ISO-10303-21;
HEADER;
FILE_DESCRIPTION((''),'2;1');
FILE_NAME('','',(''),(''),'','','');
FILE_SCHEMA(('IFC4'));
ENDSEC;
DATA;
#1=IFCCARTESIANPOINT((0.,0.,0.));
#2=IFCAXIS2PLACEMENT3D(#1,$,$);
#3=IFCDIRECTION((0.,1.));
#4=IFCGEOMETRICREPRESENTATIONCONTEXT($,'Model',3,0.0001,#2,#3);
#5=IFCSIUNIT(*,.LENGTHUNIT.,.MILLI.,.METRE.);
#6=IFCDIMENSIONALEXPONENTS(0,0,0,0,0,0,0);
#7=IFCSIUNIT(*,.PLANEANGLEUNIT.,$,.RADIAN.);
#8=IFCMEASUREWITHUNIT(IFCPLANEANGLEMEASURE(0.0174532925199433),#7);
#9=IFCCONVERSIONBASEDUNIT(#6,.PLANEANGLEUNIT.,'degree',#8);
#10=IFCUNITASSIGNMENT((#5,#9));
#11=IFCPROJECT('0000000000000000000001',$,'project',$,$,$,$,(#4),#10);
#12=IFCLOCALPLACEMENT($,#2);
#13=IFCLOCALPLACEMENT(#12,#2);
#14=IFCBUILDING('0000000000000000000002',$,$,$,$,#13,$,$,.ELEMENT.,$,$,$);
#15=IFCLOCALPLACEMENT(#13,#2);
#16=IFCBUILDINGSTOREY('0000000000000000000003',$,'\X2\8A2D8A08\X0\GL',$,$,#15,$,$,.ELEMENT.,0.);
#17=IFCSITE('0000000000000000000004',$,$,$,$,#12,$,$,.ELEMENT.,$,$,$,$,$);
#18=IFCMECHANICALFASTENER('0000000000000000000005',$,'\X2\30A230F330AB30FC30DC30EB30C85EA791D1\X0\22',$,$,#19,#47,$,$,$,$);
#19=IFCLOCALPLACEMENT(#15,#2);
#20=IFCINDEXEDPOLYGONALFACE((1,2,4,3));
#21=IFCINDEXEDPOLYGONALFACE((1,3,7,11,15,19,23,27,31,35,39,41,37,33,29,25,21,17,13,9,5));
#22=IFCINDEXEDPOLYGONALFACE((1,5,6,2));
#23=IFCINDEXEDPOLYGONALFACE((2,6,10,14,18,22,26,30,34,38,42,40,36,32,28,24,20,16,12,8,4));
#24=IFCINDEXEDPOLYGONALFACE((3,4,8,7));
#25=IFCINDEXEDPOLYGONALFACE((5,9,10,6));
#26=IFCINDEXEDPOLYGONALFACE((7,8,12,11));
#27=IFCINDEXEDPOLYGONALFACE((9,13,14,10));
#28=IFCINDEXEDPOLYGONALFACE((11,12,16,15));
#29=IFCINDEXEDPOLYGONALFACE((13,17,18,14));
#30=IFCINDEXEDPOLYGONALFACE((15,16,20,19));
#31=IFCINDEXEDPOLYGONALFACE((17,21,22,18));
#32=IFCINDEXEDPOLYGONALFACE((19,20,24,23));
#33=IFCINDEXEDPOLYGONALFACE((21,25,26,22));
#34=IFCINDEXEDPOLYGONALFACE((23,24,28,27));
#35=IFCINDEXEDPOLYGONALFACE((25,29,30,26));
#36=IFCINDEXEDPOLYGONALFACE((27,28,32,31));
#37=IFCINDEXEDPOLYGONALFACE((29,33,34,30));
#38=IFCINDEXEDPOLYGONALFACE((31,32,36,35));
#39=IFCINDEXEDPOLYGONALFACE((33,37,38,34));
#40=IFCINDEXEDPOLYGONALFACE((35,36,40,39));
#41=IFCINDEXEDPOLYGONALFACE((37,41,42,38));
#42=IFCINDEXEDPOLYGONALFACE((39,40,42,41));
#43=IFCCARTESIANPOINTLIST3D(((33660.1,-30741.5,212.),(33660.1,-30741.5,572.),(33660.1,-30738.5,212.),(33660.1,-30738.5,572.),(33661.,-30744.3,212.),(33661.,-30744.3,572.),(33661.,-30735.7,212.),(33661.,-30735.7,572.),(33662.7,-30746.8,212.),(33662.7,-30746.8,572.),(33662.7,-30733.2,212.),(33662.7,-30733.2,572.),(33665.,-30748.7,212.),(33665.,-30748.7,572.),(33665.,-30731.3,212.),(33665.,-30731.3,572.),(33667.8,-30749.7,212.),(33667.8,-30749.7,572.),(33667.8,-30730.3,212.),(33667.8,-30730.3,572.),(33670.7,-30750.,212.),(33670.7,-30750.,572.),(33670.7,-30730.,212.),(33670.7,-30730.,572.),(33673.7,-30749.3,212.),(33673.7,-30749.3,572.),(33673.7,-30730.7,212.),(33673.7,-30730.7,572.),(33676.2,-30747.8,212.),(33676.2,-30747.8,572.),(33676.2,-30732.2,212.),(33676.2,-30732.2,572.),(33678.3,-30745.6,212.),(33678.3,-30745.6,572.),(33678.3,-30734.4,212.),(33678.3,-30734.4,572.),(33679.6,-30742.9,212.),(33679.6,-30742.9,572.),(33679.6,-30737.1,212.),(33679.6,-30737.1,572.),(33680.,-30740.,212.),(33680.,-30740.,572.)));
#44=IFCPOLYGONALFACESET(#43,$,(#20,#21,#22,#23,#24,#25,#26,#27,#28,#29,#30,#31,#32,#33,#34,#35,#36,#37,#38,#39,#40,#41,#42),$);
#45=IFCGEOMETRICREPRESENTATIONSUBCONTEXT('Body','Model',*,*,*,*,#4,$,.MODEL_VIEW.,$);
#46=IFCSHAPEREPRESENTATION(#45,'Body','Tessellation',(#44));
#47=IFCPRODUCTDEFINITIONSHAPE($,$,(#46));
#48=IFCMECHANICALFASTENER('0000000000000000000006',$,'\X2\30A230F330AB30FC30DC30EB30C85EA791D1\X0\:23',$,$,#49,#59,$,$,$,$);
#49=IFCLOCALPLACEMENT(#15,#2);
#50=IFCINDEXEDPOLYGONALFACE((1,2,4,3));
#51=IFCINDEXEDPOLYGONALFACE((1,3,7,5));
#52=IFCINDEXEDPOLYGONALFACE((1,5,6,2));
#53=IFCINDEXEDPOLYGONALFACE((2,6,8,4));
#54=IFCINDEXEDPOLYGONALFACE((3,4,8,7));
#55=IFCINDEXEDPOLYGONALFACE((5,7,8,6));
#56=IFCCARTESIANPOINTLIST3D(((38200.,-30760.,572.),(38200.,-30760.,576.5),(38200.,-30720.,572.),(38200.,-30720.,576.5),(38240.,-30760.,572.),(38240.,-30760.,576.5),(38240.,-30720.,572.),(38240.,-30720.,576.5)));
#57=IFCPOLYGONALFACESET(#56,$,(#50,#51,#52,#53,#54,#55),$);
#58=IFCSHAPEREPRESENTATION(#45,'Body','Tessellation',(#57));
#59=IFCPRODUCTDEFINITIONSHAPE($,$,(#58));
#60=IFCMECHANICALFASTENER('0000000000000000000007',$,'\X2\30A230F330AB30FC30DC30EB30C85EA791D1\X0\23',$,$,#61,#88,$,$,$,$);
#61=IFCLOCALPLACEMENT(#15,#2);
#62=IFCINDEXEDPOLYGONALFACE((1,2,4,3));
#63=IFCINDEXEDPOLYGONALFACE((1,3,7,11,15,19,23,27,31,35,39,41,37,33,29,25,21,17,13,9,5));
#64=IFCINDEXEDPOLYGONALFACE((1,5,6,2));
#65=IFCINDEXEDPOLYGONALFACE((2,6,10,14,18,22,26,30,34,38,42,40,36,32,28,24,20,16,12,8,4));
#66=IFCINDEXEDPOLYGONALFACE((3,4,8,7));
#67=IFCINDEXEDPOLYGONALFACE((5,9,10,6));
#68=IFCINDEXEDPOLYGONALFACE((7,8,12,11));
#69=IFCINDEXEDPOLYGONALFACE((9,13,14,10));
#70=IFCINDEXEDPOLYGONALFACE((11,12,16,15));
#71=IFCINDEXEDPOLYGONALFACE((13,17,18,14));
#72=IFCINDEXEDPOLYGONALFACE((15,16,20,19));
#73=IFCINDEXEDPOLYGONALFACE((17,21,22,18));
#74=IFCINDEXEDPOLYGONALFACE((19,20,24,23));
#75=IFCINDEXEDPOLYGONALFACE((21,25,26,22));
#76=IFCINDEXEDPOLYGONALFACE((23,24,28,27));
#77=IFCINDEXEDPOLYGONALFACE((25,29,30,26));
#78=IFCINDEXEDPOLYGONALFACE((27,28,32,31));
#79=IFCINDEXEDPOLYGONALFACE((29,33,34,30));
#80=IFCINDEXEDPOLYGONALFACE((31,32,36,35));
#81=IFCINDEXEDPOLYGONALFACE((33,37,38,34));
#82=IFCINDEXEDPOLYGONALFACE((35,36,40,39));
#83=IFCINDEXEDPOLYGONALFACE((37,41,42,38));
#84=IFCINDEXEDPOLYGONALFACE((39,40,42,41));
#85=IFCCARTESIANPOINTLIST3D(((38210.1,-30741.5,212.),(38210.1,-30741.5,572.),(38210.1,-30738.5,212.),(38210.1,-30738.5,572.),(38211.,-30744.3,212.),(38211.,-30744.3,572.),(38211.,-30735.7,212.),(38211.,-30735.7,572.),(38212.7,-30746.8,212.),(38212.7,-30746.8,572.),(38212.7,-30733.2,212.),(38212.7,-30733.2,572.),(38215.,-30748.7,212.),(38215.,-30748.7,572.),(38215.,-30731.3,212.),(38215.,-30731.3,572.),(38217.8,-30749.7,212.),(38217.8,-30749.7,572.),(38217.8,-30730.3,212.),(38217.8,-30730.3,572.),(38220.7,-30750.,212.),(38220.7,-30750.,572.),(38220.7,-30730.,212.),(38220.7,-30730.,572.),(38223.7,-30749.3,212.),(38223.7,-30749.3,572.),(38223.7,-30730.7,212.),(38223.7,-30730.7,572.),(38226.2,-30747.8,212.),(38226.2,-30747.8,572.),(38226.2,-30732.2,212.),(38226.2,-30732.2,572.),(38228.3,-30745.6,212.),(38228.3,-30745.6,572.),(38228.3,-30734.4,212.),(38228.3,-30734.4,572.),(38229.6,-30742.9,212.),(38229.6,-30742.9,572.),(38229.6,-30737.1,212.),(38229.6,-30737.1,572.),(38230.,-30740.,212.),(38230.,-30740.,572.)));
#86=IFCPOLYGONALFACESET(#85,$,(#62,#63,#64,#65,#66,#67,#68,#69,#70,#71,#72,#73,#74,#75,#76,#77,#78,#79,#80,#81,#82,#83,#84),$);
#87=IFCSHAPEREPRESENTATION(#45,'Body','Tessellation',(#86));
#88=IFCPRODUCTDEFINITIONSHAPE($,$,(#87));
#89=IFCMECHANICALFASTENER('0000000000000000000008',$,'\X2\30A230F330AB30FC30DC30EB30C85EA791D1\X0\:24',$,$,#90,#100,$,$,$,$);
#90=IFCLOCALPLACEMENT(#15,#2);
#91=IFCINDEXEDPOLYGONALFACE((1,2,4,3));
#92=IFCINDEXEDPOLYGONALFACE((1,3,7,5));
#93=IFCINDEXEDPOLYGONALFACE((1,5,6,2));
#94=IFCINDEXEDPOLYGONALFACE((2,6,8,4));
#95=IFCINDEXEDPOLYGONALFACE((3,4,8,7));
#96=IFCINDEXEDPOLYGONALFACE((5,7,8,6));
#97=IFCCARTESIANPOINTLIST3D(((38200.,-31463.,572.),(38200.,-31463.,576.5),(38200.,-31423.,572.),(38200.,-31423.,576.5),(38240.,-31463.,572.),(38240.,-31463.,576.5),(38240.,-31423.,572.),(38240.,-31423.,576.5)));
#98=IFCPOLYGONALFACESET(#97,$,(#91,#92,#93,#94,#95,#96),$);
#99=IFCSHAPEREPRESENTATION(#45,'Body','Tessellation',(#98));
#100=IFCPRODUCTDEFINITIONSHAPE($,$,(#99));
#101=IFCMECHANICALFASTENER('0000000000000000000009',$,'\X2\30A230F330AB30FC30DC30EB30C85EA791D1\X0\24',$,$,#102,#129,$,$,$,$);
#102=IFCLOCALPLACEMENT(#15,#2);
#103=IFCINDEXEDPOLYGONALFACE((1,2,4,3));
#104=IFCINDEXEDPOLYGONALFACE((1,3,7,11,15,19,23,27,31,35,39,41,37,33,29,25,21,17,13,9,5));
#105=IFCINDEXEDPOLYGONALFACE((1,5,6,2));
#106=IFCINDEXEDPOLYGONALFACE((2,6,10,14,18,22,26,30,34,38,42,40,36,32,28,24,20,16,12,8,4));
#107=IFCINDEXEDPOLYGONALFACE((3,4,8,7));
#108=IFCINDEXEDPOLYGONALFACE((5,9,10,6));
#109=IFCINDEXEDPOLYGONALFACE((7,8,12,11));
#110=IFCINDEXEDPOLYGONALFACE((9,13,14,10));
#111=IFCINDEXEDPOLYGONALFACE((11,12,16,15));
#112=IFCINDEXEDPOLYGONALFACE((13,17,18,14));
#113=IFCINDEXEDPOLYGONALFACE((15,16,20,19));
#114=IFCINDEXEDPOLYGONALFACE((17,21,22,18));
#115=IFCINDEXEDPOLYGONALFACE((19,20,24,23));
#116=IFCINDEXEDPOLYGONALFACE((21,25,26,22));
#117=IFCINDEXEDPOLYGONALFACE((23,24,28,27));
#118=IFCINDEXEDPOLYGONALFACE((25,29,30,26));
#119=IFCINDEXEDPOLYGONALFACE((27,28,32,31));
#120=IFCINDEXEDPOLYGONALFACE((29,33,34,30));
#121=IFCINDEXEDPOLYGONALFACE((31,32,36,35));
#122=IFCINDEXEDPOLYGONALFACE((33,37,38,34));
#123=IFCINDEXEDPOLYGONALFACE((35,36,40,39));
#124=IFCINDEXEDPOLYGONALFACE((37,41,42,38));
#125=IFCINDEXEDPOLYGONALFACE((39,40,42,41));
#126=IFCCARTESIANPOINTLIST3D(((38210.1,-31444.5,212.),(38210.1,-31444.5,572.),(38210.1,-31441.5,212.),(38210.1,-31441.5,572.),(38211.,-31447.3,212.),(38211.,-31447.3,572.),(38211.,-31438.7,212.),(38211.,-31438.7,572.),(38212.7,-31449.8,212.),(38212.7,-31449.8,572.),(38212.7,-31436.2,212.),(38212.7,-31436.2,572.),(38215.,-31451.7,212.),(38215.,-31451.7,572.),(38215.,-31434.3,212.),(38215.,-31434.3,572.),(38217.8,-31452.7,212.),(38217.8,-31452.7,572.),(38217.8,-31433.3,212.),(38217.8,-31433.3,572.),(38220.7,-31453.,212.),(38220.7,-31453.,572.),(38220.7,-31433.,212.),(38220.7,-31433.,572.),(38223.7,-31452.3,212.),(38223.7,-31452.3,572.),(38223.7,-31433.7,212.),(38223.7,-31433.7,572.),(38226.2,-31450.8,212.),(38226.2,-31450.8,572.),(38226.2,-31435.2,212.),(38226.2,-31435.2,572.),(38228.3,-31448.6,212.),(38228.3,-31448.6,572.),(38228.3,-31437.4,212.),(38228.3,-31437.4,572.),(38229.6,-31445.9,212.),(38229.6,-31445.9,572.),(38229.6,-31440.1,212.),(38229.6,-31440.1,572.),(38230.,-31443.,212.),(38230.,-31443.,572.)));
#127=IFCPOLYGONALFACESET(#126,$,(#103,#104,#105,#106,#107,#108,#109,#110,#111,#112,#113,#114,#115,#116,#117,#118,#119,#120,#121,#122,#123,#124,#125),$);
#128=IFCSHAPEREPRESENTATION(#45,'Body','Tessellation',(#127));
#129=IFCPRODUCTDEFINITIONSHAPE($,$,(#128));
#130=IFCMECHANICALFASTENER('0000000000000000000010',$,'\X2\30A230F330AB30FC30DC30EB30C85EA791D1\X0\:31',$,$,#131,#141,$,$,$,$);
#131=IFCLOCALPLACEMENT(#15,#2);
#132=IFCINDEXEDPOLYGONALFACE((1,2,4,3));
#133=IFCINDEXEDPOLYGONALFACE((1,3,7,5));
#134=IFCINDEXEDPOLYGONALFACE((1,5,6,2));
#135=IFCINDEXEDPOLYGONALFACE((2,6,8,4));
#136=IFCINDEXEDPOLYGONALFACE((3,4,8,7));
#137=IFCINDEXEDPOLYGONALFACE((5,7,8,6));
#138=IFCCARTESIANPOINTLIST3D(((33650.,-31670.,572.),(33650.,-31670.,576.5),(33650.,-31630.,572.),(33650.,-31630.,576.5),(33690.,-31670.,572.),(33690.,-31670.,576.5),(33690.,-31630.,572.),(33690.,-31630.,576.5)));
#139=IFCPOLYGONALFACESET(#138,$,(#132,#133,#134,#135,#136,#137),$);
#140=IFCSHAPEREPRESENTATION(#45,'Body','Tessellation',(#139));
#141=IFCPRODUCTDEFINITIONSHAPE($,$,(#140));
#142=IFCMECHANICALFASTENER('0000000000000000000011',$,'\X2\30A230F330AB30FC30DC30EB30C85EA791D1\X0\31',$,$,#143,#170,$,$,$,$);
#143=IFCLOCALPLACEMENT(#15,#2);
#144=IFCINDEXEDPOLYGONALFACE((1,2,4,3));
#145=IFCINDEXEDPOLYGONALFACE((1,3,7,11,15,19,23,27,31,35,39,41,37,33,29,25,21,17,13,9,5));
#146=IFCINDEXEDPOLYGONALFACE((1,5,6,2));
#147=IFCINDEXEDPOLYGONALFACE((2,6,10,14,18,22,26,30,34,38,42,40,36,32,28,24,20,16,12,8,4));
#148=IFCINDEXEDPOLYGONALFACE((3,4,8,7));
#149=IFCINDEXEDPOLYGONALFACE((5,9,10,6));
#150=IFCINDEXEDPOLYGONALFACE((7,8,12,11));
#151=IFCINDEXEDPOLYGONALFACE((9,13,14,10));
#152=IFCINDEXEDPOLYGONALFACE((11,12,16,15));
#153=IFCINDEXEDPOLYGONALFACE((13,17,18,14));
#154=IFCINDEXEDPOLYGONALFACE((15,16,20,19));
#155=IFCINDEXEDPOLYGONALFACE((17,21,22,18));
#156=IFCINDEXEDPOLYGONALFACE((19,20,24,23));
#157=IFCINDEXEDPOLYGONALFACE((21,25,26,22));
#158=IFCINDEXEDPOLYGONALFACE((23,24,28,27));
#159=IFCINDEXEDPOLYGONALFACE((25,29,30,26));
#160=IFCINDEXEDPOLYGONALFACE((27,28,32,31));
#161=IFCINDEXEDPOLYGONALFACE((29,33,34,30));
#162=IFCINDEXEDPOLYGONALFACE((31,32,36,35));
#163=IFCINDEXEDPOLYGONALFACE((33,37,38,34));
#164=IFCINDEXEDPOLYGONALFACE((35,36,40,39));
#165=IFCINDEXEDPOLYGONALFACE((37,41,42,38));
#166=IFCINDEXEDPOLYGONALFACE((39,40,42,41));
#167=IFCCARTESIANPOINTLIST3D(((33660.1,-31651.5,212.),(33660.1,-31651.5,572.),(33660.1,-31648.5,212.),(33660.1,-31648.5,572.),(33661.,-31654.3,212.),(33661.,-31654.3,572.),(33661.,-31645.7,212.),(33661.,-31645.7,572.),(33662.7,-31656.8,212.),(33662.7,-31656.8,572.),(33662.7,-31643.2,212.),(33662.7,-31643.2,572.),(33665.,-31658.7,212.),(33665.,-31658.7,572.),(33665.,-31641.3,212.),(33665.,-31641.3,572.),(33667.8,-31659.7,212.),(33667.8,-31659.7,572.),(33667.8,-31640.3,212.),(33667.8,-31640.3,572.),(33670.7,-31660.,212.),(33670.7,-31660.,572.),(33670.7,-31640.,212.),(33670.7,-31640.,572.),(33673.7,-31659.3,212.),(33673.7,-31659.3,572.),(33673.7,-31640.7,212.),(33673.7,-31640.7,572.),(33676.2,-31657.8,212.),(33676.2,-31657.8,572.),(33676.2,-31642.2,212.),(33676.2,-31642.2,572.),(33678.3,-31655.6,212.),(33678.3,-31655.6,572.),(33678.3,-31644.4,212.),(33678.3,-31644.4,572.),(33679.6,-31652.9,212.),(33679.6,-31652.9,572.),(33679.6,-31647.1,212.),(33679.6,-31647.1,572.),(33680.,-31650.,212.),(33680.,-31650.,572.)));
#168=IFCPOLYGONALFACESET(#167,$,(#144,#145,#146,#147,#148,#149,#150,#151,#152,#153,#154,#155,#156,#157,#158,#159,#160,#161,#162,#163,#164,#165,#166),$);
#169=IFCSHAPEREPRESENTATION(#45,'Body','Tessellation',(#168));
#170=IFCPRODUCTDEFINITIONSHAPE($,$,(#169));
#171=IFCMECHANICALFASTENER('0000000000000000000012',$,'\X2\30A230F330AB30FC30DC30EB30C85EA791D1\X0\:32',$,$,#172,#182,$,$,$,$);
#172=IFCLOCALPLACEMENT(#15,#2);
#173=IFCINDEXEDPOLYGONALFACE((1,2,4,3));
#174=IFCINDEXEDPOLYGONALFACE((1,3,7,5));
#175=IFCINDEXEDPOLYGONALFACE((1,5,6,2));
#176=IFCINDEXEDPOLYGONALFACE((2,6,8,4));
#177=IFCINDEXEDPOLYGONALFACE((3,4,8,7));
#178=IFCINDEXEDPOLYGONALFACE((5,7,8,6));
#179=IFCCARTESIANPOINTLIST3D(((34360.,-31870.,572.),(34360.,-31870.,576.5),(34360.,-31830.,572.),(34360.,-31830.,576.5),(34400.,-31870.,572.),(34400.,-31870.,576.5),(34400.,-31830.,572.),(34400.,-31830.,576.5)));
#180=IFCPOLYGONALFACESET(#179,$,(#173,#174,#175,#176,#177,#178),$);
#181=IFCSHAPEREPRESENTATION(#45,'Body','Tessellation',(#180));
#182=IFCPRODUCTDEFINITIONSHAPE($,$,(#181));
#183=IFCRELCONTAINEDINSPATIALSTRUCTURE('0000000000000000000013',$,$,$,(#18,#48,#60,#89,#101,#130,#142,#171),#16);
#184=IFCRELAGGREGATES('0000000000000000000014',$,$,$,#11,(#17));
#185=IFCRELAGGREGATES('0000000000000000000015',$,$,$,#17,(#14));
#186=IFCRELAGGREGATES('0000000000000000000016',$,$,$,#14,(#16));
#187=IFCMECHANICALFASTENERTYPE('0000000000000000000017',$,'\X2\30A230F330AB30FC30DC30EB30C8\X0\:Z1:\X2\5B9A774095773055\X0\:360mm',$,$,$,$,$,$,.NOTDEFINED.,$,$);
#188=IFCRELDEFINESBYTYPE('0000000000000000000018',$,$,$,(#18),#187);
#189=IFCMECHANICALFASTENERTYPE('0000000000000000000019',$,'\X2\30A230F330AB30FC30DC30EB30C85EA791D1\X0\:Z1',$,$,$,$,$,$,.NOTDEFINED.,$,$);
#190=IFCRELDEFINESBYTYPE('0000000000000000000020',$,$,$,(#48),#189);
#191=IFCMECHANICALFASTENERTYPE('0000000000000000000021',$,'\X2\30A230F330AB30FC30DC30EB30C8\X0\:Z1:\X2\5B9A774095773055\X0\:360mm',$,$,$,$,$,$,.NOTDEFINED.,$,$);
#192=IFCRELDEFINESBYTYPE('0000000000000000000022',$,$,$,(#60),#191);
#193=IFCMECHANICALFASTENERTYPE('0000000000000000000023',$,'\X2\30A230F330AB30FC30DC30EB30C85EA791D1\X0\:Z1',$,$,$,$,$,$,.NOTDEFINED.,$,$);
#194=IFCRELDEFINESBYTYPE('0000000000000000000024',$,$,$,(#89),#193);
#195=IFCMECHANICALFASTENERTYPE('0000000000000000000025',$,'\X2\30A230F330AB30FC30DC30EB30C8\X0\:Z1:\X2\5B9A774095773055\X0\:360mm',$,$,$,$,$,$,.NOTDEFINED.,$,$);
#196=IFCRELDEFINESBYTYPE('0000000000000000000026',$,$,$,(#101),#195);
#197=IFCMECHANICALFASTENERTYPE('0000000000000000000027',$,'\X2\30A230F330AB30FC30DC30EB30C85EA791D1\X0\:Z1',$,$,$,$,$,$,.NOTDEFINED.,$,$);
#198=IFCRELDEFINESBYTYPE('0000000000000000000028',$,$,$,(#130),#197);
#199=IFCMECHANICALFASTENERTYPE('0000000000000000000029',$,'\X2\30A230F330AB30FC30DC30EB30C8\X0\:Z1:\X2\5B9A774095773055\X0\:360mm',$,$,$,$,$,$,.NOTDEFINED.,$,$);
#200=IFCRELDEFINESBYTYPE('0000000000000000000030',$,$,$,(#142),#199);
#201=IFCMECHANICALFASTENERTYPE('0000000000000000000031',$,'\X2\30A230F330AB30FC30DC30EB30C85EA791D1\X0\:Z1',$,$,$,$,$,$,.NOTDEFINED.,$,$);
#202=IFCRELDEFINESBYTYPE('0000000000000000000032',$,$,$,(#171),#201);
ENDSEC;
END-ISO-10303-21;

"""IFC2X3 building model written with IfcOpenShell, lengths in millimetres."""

from ifc_helpers import new_model, entity, si_unit, converted_unit, direction, frame, origin, origin_with_axes, origin_2d, place, context, subcontext, project, spatial, rectangle, circle, extrude, type_object, element, save


model = new_model("IFC2X3")

# Units and contexts
model_context = context("Model", 3, precision=0.0001, world=origin(), true_north=direction((0.0, 1.0)))
body_context = subcontext(model_context, "Body", "Model", "MODEL_VIEW")
ifc_project = project(units=[si_unit("LENGTHUNIT", "METRE", prefix="MILLI"), converted_unit("PLANEANGLEUNIT", "degree", entity("IfcPlaneAngleMeasure", 0.0174532925199433), si_unit("PLANEANGLEUNIT", "RADIAN"), dimensions=[0, 0, 0, 0, 0, 0, 0])], contexts=[model_context])

# Site, building, storey
site_placement = place(None, origin())
site = spatial("IfcSite", under=ifc_project, at=site_placement, CompositionType="ELEMENT")
building_placement = place(site_placement, origin())
building = spatial("IfcBuilding", under=site, at=building_placement, CompositionType="ELEMENT")
storey_placement = place(building_placement, origin())
storey = spatial("IfcBuildingStorey", under=building, at=storey_placement, Name="設計GL", CompositionType="ELEMENT", Elevation=0.0)

# Mechanical fasteners
mechanical_fastener_type_1 = type_object("IfcMechanicalFastenerType", Name="アンカーボルト:Z1:定着長さ:360mm")
mechanical_fastener_1_placement = place(storey_placement, frame((33670.0, -30740.0, 212.0)))
element("IfcMechanicalFastener", 1, at=mechanical_fastener_1_placement, inside=storey, type_object=mechanical_fastener_type_1, Name="アンカーボルト座金22", context=body_context, shape_type="SweptSolid", body=[
    extrude(circle(Radius=10.0, at=origin_2d()), origin_with_axes(), (0.0, 0.0, 1.0), 360.0),
])
mechanical_fastener_type_2 = type_object("IfcMechanicalFastenerType", Name="アンカーボルト座金:Z1")
mechanical_fastener_2_placement = place(storey_placement, frame((38220.0, -30740.0, 572.0)))
element("IfcMechanicalFastener", 2, at=mechanical_fastener_2_placement, inside=storey, type_object=mechanical_fastener_type_2, Name="アンカーボルト座金:23", context=body_context, shape_type="SweptSolid", body=[
    extrude(rectangle(XDim=40.0, YDim=40.0, at=origin_2d()), origin_with_axes(), (0.0, 0.0, 1.0), 4.5),
])
mechanical_fastener_type_3 = type_object("IfcMechanicalFastenerType", Name="アンカーボルト:Z1:定着長さ:360mm")
mechanical_fastener_3_placement = place(storey_placement, frame((38220.0, -30740.0, 212.0)))
element("IfcMechanicalFastener", 3, at=mechanical_fastener_3_placement, inside=storey, type_object=mechanical_fastener_type_3, Name="アンカーボルト座金23", context=body_context, shape_type="SweptSolid", body=[
    extrude(circle(Radius=10.0, at=origin_2d()), origin_with_axes(), (0.0, 0.0, 1.0), 360.0),
])
mechanical_fastener_type_4 = type_object("IfcMechanicalFastenerType", Name="アンカーボルト座金:Z1")
mechanical_fastener_4_placement = place(storey_placement, frame((38220.0, -31443.0, 572.0)))
element("IfcMechanicalFastener", 4, at=mechanical_fastener_4_placement, inside=storey, type_object=mechanical_fastener_type_4, Name="アンカーボルト座金:24", context=body_context, shape_type="SweptSolid", body=[
    extrude(rectangle(XDim=40.0, YDim=40.0, at=origin_2d()), origin_with_axes(), (0.0, 0.0, 1.0), 4.5),
])
mechanical_fastener_type_5 = type_object("IfcMechanicalFastenerType", Name="アンカーボルト:Z1:定着長さ:360mm")
mechanical_fastener_5_placement = place(storey_placement, frame((38220.0, -31443.0, 212.0)))
element("IfcMechanicalFastener", 5, at=mechanical_fastener_5_placement, inside=storey, type_object=mechanical_fastener_type_5, Name="アンカーボルト座金24", context=body_context, shape_type="SweptSolid", body=[
    extrude(circle(Radius=10.0, at=origin_2d()), origin_with_axes(), (0.0, 0.0, 1.0), 360.0),
])
mechanical_fastener_type_6 = type_object("IfcMechanicalFastenerType", Name="アンカーボルト座金:Z1")
mechanical_fastener_6_placement = place(storey_placement, frame((33670.0, -31650.0, 572.0)))
element("IfcMechanicalFastener", 6, at=mechanical_fastener_6_placement, inside=storey, type_object=mechanical_fastener_type_6, Name="アンカーボルト座金:31", context=body_context, shape_type="SweptSolid", body=[
    extrude(rectangle(XDim=40.0, YDim=40.0, at=origin_2d()), origin_with_axes(), (0.0, 0.0, 1.0), 4.5),
])
mechanical_fastener_type_7 = type_object("IfcMechanicalFastenerType", Name="アンカーボルト:Z1:定着長さ:360mm")
mechanical_fastener_7_placement = place(storey_placement, frame((33670.0, -31650.0, 212.0)))
element("IfcMechanicalFastener", 7, at=mechanical_fastener_7_placement, inside=storey, type_object=mechanical_fastener_type_7, Name="アンカーボルト座金31", context=body_context, shape_type="SweptSolid", body=[
    extrude(circle(Radius=10.0, at=origin_2d()), origin_with_axes(), (0.0, 0.0, 1.0), 360.0),
])
mechanical_fastener_type_8 = type_object("IfcMechanicalFastenerType", Name="アンカーボルト座金:Z1")
mechanical_fastener_8_placement = place(storey_placement, frame((34380.0, -31850.0, 572.0)))
element("IfcMechanicalFastener", 8, at=mechanical_fastener_8_placement, inside=storey, type_object=mechanical_fastener_type_8, Name="アンカーボルト座金:32", context=body_context, shape_type="SweptSolid", body=[
    extrude(rectangle(XDim=40.0, YDim=40.0, at=origin_2d()), origin_with_axes(), (0.0, 0.0, 1.0), 4.5),
])

save(model, "model.ifc")
